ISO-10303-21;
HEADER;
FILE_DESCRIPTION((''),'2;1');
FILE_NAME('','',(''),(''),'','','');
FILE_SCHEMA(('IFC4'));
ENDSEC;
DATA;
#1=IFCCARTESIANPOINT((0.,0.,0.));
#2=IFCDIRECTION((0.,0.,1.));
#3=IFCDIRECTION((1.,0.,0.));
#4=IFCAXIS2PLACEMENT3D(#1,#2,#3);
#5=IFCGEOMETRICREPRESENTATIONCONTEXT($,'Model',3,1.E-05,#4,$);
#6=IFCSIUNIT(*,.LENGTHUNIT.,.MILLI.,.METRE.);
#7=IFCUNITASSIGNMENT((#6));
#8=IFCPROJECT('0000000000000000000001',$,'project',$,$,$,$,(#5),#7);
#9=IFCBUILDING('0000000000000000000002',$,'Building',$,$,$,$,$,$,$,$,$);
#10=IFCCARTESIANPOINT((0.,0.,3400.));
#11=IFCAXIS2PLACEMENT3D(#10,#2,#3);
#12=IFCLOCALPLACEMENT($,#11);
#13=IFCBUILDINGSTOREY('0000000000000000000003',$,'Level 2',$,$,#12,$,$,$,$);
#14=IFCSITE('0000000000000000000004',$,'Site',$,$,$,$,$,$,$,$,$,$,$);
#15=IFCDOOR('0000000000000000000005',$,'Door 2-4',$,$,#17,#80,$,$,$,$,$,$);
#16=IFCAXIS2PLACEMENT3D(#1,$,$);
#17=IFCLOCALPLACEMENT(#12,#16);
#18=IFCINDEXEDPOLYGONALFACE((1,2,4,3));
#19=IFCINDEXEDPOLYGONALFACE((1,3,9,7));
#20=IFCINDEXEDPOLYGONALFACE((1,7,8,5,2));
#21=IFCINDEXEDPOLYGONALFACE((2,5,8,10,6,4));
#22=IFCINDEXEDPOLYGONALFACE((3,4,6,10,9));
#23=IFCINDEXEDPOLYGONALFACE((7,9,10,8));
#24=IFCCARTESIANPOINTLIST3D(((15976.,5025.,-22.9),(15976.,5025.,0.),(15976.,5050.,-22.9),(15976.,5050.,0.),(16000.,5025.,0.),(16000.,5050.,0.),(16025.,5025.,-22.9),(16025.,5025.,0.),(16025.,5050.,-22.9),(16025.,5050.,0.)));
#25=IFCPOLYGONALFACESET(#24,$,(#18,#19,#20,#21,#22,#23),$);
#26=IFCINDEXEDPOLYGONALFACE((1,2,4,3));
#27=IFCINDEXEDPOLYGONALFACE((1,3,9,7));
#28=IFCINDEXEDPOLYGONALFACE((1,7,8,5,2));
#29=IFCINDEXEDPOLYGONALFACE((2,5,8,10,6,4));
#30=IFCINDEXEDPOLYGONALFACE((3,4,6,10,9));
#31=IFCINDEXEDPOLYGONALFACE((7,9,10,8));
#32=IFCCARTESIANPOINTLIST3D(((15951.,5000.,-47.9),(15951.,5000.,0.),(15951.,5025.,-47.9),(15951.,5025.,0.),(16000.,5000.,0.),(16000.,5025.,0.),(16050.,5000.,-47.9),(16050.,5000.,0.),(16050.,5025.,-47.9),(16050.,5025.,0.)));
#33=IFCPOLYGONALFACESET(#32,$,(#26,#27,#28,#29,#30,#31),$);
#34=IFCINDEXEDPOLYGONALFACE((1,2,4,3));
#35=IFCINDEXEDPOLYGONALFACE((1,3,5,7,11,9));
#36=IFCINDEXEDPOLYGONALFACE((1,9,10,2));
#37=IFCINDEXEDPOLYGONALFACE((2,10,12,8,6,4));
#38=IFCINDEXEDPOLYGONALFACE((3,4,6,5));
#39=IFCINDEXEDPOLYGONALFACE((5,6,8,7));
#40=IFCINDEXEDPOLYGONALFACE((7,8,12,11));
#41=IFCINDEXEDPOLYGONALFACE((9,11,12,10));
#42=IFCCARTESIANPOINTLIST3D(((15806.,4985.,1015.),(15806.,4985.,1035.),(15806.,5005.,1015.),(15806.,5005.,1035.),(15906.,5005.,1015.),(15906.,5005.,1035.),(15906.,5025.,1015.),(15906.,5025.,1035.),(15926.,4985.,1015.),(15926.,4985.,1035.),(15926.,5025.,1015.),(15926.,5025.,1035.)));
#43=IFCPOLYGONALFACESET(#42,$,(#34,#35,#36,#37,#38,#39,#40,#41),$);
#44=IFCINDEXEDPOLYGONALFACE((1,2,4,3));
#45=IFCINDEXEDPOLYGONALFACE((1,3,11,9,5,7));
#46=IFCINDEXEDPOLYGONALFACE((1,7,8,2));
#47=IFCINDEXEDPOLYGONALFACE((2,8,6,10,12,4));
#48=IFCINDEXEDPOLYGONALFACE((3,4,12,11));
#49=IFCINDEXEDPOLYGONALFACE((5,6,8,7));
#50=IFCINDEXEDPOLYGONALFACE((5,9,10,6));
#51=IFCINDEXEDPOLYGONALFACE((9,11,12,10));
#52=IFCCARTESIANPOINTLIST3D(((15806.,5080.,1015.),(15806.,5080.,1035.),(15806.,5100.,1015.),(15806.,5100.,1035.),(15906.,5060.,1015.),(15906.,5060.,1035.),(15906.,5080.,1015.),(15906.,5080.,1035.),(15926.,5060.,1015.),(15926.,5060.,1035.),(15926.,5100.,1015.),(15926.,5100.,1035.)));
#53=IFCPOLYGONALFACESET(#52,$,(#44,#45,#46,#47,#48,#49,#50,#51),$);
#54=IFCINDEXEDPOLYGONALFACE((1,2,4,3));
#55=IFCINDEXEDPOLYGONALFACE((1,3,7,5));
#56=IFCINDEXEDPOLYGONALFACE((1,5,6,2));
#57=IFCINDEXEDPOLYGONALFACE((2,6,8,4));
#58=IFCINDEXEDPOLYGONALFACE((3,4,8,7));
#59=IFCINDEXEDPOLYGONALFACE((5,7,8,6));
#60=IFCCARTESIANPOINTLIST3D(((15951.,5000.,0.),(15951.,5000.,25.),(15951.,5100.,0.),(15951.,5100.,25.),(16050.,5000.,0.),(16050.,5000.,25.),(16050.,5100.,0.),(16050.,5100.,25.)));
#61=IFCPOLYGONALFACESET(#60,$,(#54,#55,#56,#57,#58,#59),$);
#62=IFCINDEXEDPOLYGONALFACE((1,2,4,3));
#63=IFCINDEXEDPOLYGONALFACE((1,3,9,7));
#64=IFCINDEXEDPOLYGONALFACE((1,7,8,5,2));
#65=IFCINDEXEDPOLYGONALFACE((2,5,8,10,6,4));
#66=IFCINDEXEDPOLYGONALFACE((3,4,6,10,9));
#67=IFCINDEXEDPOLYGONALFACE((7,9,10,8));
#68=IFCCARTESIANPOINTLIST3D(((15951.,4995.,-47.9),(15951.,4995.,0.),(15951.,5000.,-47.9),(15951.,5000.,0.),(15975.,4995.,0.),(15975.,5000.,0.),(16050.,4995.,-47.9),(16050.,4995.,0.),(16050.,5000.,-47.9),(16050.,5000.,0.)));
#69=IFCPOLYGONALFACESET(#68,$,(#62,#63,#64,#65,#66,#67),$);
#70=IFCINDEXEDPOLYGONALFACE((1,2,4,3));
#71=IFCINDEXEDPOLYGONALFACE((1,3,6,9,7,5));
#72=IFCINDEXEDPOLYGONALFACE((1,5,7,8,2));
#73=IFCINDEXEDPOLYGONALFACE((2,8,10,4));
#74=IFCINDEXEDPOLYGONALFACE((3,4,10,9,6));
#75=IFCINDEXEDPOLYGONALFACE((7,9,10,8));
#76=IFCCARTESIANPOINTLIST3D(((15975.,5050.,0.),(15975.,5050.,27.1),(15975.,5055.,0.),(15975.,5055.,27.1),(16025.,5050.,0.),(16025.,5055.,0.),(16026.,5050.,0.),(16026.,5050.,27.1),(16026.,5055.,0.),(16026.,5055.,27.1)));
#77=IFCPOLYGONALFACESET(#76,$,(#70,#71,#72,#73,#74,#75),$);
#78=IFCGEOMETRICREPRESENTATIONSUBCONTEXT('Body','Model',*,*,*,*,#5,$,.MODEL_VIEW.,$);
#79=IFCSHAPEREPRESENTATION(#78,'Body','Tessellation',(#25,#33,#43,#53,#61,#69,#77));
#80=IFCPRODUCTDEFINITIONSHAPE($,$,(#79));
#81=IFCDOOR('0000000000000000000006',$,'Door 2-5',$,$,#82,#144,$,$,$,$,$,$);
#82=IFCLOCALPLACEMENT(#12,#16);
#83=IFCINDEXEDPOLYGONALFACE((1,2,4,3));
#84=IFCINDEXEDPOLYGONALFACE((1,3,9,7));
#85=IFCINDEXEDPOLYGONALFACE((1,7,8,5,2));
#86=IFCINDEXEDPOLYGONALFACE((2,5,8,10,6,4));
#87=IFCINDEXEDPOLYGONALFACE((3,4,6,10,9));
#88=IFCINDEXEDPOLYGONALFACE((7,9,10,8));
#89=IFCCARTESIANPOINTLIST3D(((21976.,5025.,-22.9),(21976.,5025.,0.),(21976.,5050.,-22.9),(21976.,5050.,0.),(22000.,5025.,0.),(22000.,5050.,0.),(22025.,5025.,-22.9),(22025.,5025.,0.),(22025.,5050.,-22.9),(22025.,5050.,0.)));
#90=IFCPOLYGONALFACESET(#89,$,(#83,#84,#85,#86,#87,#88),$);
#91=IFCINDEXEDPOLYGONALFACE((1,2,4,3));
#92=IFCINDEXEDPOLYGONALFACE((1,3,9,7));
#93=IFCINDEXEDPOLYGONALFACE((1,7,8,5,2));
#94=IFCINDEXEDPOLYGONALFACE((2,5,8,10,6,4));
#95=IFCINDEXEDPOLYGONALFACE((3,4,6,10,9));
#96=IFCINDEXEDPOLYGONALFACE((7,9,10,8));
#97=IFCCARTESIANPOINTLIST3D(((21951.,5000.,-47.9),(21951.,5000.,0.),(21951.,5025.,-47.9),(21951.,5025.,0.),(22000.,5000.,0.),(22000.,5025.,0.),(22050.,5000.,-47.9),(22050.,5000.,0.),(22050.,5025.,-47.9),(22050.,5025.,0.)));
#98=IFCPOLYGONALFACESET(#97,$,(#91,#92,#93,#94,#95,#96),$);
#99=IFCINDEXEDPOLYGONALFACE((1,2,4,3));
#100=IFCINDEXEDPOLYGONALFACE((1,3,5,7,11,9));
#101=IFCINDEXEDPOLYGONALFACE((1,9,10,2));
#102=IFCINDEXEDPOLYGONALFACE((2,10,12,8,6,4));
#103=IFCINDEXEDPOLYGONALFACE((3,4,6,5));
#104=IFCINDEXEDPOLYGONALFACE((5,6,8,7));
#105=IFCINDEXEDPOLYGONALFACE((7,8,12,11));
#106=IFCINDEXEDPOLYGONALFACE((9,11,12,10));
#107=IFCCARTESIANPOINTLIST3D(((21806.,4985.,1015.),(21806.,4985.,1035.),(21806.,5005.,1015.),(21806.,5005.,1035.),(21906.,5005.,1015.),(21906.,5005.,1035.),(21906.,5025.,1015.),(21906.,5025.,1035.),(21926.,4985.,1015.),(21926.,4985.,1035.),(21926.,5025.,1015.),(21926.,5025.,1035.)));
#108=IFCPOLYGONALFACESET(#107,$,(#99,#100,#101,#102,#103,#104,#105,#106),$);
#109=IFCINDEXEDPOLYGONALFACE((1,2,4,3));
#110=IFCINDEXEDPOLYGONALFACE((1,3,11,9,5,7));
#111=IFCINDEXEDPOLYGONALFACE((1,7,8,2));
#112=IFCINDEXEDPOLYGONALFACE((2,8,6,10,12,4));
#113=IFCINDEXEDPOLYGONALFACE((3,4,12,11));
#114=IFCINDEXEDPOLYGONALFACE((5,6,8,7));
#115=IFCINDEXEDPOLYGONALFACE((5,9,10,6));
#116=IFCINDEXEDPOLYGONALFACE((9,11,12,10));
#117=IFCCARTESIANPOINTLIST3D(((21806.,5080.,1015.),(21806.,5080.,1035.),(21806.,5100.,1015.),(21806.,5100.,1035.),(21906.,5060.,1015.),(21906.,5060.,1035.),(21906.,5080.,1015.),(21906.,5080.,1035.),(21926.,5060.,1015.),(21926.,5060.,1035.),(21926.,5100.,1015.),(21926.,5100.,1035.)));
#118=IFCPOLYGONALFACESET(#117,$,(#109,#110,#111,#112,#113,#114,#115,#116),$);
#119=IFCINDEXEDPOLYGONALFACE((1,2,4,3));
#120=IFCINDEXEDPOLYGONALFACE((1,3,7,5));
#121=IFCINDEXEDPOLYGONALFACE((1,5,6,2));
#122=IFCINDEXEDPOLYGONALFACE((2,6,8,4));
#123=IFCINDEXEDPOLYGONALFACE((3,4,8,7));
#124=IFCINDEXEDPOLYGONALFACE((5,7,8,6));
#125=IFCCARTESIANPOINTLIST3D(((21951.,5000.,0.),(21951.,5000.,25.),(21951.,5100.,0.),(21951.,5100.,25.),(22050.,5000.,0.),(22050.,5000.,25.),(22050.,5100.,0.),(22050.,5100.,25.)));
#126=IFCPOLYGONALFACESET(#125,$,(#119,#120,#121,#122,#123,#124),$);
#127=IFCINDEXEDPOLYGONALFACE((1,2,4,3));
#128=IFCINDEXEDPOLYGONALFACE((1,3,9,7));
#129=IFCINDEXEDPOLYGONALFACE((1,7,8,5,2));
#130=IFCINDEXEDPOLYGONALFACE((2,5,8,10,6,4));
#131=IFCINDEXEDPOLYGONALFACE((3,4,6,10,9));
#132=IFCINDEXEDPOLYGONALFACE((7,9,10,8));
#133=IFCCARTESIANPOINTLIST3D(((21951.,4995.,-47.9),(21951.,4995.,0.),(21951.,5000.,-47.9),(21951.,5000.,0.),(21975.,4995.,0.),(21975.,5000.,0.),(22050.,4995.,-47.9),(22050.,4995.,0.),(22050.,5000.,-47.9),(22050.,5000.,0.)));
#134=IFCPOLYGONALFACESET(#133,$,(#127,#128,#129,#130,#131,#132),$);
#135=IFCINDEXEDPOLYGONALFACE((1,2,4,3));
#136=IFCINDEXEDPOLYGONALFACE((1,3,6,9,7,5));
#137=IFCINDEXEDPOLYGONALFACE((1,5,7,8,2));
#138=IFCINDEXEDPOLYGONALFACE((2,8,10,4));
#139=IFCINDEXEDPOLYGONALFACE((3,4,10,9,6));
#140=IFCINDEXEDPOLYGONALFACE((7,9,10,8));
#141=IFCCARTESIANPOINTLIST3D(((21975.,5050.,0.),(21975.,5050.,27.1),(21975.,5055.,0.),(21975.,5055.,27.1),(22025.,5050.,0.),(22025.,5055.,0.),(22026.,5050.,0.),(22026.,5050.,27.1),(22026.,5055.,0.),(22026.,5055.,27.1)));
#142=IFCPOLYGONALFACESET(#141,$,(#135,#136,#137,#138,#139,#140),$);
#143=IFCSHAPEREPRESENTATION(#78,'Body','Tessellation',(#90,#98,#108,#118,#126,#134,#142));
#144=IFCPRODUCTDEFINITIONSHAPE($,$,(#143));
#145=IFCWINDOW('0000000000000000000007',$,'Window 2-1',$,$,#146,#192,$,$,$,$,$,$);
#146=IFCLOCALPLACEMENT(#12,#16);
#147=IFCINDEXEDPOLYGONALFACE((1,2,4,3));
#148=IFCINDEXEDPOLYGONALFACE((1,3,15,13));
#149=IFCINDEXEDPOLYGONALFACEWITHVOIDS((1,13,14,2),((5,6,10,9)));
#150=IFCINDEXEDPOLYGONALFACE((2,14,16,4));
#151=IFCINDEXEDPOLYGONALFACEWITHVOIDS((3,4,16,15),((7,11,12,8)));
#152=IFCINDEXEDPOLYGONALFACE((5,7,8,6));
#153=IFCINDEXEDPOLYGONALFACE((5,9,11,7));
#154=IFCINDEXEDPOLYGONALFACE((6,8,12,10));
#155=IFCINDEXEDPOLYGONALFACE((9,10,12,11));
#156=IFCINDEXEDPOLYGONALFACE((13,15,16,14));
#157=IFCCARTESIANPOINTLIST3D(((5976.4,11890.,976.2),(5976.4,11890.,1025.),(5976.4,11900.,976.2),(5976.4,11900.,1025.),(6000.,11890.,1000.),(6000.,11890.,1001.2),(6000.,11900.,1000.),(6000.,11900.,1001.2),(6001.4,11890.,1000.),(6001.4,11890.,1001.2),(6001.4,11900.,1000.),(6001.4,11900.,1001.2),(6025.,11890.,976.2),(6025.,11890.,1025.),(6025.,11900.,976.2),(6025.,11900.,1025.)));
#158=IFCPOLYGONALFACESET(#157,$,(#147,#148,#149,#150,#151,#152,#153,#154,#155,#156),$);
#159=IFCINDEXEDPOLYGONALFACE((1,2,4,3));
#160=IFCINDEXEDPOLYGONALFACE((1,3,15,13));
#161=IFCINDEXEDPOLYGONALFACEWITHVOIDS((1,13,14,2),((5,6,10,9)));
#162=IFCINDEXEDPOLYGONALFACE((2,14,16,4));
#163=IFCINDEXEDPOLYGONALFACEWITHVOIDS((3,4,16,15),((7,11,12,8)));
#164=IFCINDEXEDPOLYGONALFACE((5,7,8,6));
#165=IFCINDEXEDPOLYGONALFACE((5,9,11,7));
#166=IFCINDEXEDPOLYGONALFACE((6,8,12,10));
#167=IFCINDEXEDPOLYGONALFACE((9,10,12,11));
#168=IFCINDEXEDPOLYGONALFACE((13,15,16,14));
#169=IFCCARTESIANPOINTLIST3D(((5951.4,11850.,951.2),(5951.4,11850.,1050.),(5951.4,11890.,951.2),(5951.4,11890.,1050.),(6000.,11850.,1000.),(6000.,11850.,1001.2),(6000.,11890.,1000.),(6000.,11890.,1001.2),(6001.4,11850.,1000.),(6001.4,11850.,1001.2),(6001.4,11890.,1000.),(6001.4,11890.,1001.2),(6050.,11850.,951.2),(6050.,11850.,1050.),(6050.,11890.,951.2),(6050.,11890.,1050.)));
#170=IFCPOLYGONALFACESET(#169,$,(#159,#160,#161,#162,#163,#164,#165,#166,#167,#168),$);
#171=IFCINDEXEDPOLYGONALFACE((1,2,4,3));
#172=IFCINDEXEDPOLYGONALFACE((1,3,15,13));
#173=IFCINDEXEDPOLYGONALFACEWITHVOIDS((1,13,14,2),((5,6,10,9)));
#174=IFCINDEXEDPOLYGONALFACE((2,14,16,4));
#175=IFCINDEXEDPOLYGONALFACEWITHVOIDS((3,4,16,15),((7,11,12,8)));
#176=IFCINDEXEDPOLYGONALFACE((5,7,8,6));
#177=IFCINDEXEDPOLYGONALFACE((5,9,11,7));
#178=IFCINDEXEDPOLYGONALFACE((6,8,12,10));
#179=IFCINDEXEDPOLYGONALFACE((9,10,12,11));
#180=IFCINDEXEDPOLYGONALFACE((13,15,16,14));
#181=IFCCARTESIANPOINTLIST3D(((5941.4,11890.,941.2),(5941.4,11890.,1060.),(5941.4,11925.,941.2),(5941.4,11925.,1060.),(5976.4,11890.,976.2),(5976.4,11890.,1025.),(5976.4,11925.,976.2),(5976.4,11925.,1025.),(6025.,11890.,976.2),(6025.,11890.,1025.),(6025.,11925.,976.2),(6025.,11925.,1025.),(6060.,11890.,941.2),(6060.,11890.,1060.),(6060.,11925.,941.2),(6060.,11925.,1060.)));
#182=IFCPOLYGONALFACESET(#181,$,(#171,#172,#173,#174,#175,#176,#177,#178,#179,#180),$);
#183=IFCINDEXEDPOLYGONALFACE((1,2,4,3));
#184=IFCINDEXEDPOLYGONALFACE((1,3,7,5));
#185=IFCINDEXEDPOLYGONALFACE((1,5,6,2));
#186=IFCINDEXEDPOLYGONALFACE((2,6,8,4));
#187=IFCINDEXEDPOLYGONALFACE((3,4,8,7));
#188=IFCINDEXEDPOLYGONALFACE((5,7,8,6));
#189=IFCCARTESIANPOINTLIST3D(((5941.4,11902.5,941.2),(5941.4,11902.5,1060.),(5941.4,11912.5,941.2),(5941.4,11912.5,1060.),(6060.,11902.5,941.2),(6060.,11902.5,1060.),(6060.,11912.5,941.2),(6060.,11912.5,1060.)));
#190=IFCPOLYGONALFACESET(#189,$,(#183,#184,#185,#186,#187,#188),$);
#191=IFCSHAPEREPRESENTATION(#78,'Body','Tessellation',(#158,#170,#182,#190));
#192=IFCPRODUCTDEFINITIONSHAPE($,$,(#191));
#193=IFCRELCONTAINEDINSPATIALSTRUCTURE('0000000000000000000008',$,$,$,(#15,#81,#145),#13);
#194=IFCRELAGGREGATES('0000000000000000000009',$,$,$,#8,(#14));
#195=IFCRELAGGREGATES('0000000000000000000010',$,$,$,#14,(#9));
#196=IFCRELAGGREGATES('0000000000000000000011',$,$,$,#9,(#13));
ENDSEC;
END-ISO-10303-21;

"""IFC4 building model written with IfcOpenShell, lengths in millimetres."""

from ifc_helpers import new_model, si_unit, frame, origin_with_axes, place, context, subcontext, project, spatial, line, indexed_curve, outline, extrude, element, save


model = new_model("IFC4")

# Units and contexts
model_context = context("Model", 3, precision=1e-05, world=origin_with_axes())
body_context = subcontext(model_context, "Body", "Model", "MODEL_VIEW")
ifc_project = project(units=[si_unit("LENGTHUNIT", "METRE", prefix="MILLI")], contexts=[model_context])

# Site, building, storey
site = spatial("IfcSite", under=ifc_project, Name="Site")
building = spatial("IfcBuilding", under=site, Name="Building")
storey_placement = place(None, frame((0.0, 0.0, 3400.0), z_axis=(0.0, 0.0, 1.0), x_axis=(1.0, 0.0, 0.0)))
storey = spatial("IfcBuildingStorey", under=building, at=storey_placement, Name="Level 2")

# Doors
door_1_placement = place(storey_placement, frame((16000.0, 5000.0, 0.0), z_axis=(0.0, 0.0, 1.0), x_axis=(1.0, 0.0, 0.0)))
element("IfcDoor", 1, at=door_1_placement, inside=storey, Name="Door 2-4", context=body_context, shape_type="SweptSolid", body=[
    extrude(outline(indexed_curve([(0.0, 0.0), (0.0, 2.1), (1.0, 2.1), (1.0, 0.0), (-24.0, 0.0), (-24.0, -22.9), (25.0, -22.9), (25.0, 0.0)], segments=[line(1, 2, 3, 4, 5, 6, 7, 8, 1)])), frame((0.0, 25.0, 0.0), z_axis=(0.0, -1.0, 0.0), x_axis=(1.0, 0.0, 0.0)), (0.0, 0.0, -1.0), 25.0),
    extrude(outline(indexed_curve([(0.0, 0.0), (0.0, 2.1), (1.0, 2.1), (1.0, 0.0), (-49.0, 0.0), (-49.0, -47.9), (50.0, -47.9), (50.0, 0.0)], segments=[line(1, 2, 3, 4, 5, 6, 7, 8, 1)])), frame((0.0, 0.0, 0.0), z_axis=(0.0, -1.0, 0.0), x_axis=(1.0, 0.0, 0.0)), (0.0, 0.0, -1.0), 25.0),
    extrude(outline(indexed_curve([(0.0, 0.0), (-49.0, 0.0), (-49.0, 35.0), (0.0, 35.0)], segments=[line(1, 2, 3, 4, 1)])), frame((25.0, 25.0, 25.0), z_axis=(0.0, 0.0, 1.0), x_axis=(1.0, 0.0, 0.0)), (0.0, 0.0, 1.0), -47.9),
    extrude(outline(indexed_curve([(0.0, 0.0), (0.0, -40.0), (-120.0, -40.0), (-120.0, -20.0), (-20.0, -20.0), (-20.0, 0.0)], segments=[line(1, 2, 3, 4, 5, 6, 1)])), frame((-74.0, 25.0, 1015.0), z_axis=(0.0, 0.0, 1.0), x_axis=(1.0, 0.0, 0.0)), (0.0, 0.0, 1.0), 20.0),
    extrude(outline(indexed_curve([(0.0, 0.0), (0.0, 40.0), (-120.0, 40.0), (-120.0, 20.0), (-20.0, 20.0), (-20.0, 0.0)], segments=[line(1, 2, 3, 4, 5, 6, 1)])), frame((-74.0, 60.0, 1015.0), z_axis=(0.0, 0.0, 1.0), x_axis=(1.0, 0.0, 0.0)), (0.0, 0.0, 1.0), 20.0),
    extrude(outline(indexed_curve([(0.0, 0.0), (-99.0, 0.0), (-99.0, 100.0), (0.0, 100.0)], segments=[line(1, 2, 3, 4, 1)])), frame((50.0, 0.0, 0.0), z_axis=(0.0, 0.0, 1.0), x_axis=(1.0, 0.0, 0.0)), (0.0, 0.0, 1.0), 25.0),
    extrude(outline(indexed_curve([(0.0, 0.0), (0.0, 27.1), (51.0, 27.1), (51.0, 0.0), (-24.0, 0.0), (-24.0, -47.9), (75.0, -47.9), (75.0, 0.0)], segments=[line(1, 2, 3, 4, 5, 6, 7, 8, 1)])), frame((-25.0, -5.0, 0.0), z_axis=(0.0, -1.0, 0.0), x_axis=(1.0, 0.0, 0.0)), (0.0, 0.0, -1.0), 5.0),
    extrude(outline(indexed_curve([(0.0, 0.0), (0.0, 27.1), (51.0, 27.1), (51.0, 0.0), (1.0, 0.0), (1.0, -22.9), (50.0, -22.9), (50.0, 0.0)], segments=[line(1, 2, 3, 4, 5, 6, 7, 8, 1)])), frame((-25.0, 50.0, 0.0), z_axis=(0.0, -1.0, 0.0), x_axis=(1.0, 0.0, 0.0)), (0.0, 0.0, -1.0), 5.0),
])
door_2_placement = place(storey_placement, frame((22000.0, 5000.0, 0.0), z_axis=(0.0, 0.0, 1.0), x_axis=(1.0, 0.0, 0.0)))
element("IfcDoor", 2, at=door_2_placement, inside=storey, Name="Door 2-5", context=body_context, shape_type="SweptSolid", body=[
    extrude(outline(indexed_curve([(0.0, 0.0), (0.0, 2.1), (1.0, 2.1), (1.0, 0.0), (-24.0, 0.0), (-24.0, -22.9), (25.0, -22.9), (25.0, 0.0)], segments=[line(1, 2, 3, 4, 5, 6, 7, 8, 1)])), frame((0.0, 25.0, 0.0), z_axis=(0.0, -1.0, 0.0), x_axis=(1.0, 0.0, 0.0)), (0.0, 0.0, -1.0), 25.0),
    extrude(outline(indexed_curve([(0.0, 0.0), (0.0, 2.1), (1.0, 2.1), (1.0, 0.0), (-49.0, 0.0), (-49.0, -47.9), (50.0, -47.9), (50.0, 0.0)], segments=[line(1, 2, 3, 4, 5, 6, 7, 8, 1)])), frame((0.0, 0.0, 0.0), z_axis=(0.0, -1.0, 0.0), x_axis=(1.0, 0.0, 0.0)), (0.0, 0.0, -1.0), 25.0),
    extrude(outline(indexed_curve([(0.0, 0.0), (-49.0, 0.0), (-49.0, 35.0), (0.0, 35.0)], segments=[line(1, 2, 3, 4, 1)])), frame((25.0, 25.0, 25.0), z_axis=(0.0, 0.0, 1.0), x_axis=(1.0, 0.0, 0.0)), (0.0, 0.0, 1.0), -47.9),
    extrude(outline(indexed_curve([(0.0, 0.0), (0.0, -40.0), (-120.0, -40.0), (-120.0, -20.0), (-20.0, -20.0), (-20.0, 0.0)], segments=[line(1, 2, 3, 4, 5, 6, 1)])), frame((-74.0, 25.0, 1015.0), z_axis=(0.0, 0.0, 1.0), x_axis=(1.0, 0.0, 0.0)), (0.0, 0.0, 1.0), 20.0),
    extrude(outline(indexed_curve([(0.0, 0.0), (0.0, 40.0), (-120.0, 40.0), (-120.0, 20.0), (-20.0, 20.0), (-20.0, 0.0)], segments=[line(1, 2, 3, 4, 5, 6, 1)])), frame((-74.0, 60.0, 1015.0), z_axis=(0.0, 0.0, 1.0), x_axis=(1.0, 0.0, 0.0)), (0.0, 0.0, 1.0), 20.0),
    extrude(outline(indexed_curve([(0.0, 0.0), (-99.0, 0.0), (-99.0, 100.0), (0.0, 100.0)], segments=[line(1, 2, 3, 4, 1)])), frame((50.0, 0.0, 0.0), z_axis=(0.0, 0.0, 1.0), x_axis=(1.0, 0.0, 0.0)), (0.0, 0.0, 1.0), 25.0),
    extrude(outline(indexed_curve([(0.0, 0.0), (0.0, 27.1), (51.0, 27.1), (51.0, 0.0), (-24.0, 0.0), (-24.0, -47.9), (75.0, -47.9), (75.0, 0.0)], segments=[line(1, 2, 3, 4, 5, 6, 7, 8, 1)])), frame((-25.0, -5.0, 0.0), z_axis=(0.0, -1.0, 0.0), x_axis=(1.0, 0.0, 0.0)), (0.0, 0.0, -1.0), 5.0),
    extrude(outline(indexed_curve([(0.0, 0.0), (0.0, 27.1), (51.0, 27.1), (51.0, 0.0), (1.0, 0.0), (1.0, -22.9), (50.0, -22.9), (50.0, 0.0)], segments=[line(1, 2, 3, 4, 5, 6, 7, 8, 1)])), frame((-25.0, 50.0, 0.0), z_axis=(0.0, -1.0, 0.0), x_axis=(1.0, 0.0, 0.0)), (0.0, 0.0, -1.0), 5.0),
])

# Window
for number, where, z_axis, x_axis, name in (
    (3, (6000.0, 11800.0, 1000.0), (0.0, 0.0, 1.0), (1.0, 0.0, 0.0), "Window 2-1"),
):
    element("IfcWindow", number, at=place(storey_placement, frame(where, z_axis=z_axis, x_axis=x_axis)), inside=storey, Name=name, context=body_context, shape_type="SweptSolid", body=[
        extrude(outline(indexed_curve([(0.0, 0.0), (1.4, 0.0), (1.4, 1.2), (0.0, 1.2)], segments=[line(1, 2, 3, 4, 1)]), holes=[indexed_curve([(25.0, 25.0), (-23.6, 25.0), (-23.6, -23.8), (25.0, -23.8)], segments=[line(1, 2, 3, 4, 1)])]), frame((0.0, 90.0, 0.0), z_axis=(0.0, -1.0, 0.0), x_axis=(1.0, 0.0, 0.0)), (0.0, 0.0, -1.0), 10.0),
        extrude(outline(indexed_curve([(0.0, 0.0), (1.4, 0.0), (1.4, 1.2), (0.0, 1.2)], segments=[line(1, 2, 3, 4, 1)]), holes=[indexed_curve([(50.0, 50.0), (-48.6, 50.0), (-48.6, -48.8), (50.0, -48.8)], segments=[line(1, 2, 3, 4, 1)])]), frame((0.0, 50.0, 0.0), z_axis=(0.0, -1.0, 0.0), x_axis=(1.0, 0.0, 0.0)), (0.0, 0.0, -1.0), 40.0),
        extrude(outline(indexed_curve([(0.0, 0.0), (-48.6, 0.0), (-48.6, -48.8), (0.0, -48.8)], segments=[line(1, 2, 3, 4, 1)]), holes=[indexed_curve([(35.0, 35.0), (-83.6, 35.0), (-83.6, -83.8), (35.0, -83.8)], segments=[line(1, 2, 3, 4, 1)])]), frame((25.0, 90.0, 25.0), z_axis=(0.0, -1.0, 0.0), x_axis=(1.0, 0.0, 0.0)), (0.0, 0.0, -1.0), 35.0),
        extrude(outline(indexed_curve([(35.0, 35.0), (-83.6, 35.0), (-83.6, -83.8), (35.0, -83.8)], segments=[line(1, 2, 3, 4, 1)])), frame((25.0, 102.5, 25.0), z_axis=(0.0, -1.0, 0.0), x_axis=(1.0, 0.0, 0.0)), (0.0, 0.0, -1.0), 10.0),
    ])

save(model, "model.ifc")
